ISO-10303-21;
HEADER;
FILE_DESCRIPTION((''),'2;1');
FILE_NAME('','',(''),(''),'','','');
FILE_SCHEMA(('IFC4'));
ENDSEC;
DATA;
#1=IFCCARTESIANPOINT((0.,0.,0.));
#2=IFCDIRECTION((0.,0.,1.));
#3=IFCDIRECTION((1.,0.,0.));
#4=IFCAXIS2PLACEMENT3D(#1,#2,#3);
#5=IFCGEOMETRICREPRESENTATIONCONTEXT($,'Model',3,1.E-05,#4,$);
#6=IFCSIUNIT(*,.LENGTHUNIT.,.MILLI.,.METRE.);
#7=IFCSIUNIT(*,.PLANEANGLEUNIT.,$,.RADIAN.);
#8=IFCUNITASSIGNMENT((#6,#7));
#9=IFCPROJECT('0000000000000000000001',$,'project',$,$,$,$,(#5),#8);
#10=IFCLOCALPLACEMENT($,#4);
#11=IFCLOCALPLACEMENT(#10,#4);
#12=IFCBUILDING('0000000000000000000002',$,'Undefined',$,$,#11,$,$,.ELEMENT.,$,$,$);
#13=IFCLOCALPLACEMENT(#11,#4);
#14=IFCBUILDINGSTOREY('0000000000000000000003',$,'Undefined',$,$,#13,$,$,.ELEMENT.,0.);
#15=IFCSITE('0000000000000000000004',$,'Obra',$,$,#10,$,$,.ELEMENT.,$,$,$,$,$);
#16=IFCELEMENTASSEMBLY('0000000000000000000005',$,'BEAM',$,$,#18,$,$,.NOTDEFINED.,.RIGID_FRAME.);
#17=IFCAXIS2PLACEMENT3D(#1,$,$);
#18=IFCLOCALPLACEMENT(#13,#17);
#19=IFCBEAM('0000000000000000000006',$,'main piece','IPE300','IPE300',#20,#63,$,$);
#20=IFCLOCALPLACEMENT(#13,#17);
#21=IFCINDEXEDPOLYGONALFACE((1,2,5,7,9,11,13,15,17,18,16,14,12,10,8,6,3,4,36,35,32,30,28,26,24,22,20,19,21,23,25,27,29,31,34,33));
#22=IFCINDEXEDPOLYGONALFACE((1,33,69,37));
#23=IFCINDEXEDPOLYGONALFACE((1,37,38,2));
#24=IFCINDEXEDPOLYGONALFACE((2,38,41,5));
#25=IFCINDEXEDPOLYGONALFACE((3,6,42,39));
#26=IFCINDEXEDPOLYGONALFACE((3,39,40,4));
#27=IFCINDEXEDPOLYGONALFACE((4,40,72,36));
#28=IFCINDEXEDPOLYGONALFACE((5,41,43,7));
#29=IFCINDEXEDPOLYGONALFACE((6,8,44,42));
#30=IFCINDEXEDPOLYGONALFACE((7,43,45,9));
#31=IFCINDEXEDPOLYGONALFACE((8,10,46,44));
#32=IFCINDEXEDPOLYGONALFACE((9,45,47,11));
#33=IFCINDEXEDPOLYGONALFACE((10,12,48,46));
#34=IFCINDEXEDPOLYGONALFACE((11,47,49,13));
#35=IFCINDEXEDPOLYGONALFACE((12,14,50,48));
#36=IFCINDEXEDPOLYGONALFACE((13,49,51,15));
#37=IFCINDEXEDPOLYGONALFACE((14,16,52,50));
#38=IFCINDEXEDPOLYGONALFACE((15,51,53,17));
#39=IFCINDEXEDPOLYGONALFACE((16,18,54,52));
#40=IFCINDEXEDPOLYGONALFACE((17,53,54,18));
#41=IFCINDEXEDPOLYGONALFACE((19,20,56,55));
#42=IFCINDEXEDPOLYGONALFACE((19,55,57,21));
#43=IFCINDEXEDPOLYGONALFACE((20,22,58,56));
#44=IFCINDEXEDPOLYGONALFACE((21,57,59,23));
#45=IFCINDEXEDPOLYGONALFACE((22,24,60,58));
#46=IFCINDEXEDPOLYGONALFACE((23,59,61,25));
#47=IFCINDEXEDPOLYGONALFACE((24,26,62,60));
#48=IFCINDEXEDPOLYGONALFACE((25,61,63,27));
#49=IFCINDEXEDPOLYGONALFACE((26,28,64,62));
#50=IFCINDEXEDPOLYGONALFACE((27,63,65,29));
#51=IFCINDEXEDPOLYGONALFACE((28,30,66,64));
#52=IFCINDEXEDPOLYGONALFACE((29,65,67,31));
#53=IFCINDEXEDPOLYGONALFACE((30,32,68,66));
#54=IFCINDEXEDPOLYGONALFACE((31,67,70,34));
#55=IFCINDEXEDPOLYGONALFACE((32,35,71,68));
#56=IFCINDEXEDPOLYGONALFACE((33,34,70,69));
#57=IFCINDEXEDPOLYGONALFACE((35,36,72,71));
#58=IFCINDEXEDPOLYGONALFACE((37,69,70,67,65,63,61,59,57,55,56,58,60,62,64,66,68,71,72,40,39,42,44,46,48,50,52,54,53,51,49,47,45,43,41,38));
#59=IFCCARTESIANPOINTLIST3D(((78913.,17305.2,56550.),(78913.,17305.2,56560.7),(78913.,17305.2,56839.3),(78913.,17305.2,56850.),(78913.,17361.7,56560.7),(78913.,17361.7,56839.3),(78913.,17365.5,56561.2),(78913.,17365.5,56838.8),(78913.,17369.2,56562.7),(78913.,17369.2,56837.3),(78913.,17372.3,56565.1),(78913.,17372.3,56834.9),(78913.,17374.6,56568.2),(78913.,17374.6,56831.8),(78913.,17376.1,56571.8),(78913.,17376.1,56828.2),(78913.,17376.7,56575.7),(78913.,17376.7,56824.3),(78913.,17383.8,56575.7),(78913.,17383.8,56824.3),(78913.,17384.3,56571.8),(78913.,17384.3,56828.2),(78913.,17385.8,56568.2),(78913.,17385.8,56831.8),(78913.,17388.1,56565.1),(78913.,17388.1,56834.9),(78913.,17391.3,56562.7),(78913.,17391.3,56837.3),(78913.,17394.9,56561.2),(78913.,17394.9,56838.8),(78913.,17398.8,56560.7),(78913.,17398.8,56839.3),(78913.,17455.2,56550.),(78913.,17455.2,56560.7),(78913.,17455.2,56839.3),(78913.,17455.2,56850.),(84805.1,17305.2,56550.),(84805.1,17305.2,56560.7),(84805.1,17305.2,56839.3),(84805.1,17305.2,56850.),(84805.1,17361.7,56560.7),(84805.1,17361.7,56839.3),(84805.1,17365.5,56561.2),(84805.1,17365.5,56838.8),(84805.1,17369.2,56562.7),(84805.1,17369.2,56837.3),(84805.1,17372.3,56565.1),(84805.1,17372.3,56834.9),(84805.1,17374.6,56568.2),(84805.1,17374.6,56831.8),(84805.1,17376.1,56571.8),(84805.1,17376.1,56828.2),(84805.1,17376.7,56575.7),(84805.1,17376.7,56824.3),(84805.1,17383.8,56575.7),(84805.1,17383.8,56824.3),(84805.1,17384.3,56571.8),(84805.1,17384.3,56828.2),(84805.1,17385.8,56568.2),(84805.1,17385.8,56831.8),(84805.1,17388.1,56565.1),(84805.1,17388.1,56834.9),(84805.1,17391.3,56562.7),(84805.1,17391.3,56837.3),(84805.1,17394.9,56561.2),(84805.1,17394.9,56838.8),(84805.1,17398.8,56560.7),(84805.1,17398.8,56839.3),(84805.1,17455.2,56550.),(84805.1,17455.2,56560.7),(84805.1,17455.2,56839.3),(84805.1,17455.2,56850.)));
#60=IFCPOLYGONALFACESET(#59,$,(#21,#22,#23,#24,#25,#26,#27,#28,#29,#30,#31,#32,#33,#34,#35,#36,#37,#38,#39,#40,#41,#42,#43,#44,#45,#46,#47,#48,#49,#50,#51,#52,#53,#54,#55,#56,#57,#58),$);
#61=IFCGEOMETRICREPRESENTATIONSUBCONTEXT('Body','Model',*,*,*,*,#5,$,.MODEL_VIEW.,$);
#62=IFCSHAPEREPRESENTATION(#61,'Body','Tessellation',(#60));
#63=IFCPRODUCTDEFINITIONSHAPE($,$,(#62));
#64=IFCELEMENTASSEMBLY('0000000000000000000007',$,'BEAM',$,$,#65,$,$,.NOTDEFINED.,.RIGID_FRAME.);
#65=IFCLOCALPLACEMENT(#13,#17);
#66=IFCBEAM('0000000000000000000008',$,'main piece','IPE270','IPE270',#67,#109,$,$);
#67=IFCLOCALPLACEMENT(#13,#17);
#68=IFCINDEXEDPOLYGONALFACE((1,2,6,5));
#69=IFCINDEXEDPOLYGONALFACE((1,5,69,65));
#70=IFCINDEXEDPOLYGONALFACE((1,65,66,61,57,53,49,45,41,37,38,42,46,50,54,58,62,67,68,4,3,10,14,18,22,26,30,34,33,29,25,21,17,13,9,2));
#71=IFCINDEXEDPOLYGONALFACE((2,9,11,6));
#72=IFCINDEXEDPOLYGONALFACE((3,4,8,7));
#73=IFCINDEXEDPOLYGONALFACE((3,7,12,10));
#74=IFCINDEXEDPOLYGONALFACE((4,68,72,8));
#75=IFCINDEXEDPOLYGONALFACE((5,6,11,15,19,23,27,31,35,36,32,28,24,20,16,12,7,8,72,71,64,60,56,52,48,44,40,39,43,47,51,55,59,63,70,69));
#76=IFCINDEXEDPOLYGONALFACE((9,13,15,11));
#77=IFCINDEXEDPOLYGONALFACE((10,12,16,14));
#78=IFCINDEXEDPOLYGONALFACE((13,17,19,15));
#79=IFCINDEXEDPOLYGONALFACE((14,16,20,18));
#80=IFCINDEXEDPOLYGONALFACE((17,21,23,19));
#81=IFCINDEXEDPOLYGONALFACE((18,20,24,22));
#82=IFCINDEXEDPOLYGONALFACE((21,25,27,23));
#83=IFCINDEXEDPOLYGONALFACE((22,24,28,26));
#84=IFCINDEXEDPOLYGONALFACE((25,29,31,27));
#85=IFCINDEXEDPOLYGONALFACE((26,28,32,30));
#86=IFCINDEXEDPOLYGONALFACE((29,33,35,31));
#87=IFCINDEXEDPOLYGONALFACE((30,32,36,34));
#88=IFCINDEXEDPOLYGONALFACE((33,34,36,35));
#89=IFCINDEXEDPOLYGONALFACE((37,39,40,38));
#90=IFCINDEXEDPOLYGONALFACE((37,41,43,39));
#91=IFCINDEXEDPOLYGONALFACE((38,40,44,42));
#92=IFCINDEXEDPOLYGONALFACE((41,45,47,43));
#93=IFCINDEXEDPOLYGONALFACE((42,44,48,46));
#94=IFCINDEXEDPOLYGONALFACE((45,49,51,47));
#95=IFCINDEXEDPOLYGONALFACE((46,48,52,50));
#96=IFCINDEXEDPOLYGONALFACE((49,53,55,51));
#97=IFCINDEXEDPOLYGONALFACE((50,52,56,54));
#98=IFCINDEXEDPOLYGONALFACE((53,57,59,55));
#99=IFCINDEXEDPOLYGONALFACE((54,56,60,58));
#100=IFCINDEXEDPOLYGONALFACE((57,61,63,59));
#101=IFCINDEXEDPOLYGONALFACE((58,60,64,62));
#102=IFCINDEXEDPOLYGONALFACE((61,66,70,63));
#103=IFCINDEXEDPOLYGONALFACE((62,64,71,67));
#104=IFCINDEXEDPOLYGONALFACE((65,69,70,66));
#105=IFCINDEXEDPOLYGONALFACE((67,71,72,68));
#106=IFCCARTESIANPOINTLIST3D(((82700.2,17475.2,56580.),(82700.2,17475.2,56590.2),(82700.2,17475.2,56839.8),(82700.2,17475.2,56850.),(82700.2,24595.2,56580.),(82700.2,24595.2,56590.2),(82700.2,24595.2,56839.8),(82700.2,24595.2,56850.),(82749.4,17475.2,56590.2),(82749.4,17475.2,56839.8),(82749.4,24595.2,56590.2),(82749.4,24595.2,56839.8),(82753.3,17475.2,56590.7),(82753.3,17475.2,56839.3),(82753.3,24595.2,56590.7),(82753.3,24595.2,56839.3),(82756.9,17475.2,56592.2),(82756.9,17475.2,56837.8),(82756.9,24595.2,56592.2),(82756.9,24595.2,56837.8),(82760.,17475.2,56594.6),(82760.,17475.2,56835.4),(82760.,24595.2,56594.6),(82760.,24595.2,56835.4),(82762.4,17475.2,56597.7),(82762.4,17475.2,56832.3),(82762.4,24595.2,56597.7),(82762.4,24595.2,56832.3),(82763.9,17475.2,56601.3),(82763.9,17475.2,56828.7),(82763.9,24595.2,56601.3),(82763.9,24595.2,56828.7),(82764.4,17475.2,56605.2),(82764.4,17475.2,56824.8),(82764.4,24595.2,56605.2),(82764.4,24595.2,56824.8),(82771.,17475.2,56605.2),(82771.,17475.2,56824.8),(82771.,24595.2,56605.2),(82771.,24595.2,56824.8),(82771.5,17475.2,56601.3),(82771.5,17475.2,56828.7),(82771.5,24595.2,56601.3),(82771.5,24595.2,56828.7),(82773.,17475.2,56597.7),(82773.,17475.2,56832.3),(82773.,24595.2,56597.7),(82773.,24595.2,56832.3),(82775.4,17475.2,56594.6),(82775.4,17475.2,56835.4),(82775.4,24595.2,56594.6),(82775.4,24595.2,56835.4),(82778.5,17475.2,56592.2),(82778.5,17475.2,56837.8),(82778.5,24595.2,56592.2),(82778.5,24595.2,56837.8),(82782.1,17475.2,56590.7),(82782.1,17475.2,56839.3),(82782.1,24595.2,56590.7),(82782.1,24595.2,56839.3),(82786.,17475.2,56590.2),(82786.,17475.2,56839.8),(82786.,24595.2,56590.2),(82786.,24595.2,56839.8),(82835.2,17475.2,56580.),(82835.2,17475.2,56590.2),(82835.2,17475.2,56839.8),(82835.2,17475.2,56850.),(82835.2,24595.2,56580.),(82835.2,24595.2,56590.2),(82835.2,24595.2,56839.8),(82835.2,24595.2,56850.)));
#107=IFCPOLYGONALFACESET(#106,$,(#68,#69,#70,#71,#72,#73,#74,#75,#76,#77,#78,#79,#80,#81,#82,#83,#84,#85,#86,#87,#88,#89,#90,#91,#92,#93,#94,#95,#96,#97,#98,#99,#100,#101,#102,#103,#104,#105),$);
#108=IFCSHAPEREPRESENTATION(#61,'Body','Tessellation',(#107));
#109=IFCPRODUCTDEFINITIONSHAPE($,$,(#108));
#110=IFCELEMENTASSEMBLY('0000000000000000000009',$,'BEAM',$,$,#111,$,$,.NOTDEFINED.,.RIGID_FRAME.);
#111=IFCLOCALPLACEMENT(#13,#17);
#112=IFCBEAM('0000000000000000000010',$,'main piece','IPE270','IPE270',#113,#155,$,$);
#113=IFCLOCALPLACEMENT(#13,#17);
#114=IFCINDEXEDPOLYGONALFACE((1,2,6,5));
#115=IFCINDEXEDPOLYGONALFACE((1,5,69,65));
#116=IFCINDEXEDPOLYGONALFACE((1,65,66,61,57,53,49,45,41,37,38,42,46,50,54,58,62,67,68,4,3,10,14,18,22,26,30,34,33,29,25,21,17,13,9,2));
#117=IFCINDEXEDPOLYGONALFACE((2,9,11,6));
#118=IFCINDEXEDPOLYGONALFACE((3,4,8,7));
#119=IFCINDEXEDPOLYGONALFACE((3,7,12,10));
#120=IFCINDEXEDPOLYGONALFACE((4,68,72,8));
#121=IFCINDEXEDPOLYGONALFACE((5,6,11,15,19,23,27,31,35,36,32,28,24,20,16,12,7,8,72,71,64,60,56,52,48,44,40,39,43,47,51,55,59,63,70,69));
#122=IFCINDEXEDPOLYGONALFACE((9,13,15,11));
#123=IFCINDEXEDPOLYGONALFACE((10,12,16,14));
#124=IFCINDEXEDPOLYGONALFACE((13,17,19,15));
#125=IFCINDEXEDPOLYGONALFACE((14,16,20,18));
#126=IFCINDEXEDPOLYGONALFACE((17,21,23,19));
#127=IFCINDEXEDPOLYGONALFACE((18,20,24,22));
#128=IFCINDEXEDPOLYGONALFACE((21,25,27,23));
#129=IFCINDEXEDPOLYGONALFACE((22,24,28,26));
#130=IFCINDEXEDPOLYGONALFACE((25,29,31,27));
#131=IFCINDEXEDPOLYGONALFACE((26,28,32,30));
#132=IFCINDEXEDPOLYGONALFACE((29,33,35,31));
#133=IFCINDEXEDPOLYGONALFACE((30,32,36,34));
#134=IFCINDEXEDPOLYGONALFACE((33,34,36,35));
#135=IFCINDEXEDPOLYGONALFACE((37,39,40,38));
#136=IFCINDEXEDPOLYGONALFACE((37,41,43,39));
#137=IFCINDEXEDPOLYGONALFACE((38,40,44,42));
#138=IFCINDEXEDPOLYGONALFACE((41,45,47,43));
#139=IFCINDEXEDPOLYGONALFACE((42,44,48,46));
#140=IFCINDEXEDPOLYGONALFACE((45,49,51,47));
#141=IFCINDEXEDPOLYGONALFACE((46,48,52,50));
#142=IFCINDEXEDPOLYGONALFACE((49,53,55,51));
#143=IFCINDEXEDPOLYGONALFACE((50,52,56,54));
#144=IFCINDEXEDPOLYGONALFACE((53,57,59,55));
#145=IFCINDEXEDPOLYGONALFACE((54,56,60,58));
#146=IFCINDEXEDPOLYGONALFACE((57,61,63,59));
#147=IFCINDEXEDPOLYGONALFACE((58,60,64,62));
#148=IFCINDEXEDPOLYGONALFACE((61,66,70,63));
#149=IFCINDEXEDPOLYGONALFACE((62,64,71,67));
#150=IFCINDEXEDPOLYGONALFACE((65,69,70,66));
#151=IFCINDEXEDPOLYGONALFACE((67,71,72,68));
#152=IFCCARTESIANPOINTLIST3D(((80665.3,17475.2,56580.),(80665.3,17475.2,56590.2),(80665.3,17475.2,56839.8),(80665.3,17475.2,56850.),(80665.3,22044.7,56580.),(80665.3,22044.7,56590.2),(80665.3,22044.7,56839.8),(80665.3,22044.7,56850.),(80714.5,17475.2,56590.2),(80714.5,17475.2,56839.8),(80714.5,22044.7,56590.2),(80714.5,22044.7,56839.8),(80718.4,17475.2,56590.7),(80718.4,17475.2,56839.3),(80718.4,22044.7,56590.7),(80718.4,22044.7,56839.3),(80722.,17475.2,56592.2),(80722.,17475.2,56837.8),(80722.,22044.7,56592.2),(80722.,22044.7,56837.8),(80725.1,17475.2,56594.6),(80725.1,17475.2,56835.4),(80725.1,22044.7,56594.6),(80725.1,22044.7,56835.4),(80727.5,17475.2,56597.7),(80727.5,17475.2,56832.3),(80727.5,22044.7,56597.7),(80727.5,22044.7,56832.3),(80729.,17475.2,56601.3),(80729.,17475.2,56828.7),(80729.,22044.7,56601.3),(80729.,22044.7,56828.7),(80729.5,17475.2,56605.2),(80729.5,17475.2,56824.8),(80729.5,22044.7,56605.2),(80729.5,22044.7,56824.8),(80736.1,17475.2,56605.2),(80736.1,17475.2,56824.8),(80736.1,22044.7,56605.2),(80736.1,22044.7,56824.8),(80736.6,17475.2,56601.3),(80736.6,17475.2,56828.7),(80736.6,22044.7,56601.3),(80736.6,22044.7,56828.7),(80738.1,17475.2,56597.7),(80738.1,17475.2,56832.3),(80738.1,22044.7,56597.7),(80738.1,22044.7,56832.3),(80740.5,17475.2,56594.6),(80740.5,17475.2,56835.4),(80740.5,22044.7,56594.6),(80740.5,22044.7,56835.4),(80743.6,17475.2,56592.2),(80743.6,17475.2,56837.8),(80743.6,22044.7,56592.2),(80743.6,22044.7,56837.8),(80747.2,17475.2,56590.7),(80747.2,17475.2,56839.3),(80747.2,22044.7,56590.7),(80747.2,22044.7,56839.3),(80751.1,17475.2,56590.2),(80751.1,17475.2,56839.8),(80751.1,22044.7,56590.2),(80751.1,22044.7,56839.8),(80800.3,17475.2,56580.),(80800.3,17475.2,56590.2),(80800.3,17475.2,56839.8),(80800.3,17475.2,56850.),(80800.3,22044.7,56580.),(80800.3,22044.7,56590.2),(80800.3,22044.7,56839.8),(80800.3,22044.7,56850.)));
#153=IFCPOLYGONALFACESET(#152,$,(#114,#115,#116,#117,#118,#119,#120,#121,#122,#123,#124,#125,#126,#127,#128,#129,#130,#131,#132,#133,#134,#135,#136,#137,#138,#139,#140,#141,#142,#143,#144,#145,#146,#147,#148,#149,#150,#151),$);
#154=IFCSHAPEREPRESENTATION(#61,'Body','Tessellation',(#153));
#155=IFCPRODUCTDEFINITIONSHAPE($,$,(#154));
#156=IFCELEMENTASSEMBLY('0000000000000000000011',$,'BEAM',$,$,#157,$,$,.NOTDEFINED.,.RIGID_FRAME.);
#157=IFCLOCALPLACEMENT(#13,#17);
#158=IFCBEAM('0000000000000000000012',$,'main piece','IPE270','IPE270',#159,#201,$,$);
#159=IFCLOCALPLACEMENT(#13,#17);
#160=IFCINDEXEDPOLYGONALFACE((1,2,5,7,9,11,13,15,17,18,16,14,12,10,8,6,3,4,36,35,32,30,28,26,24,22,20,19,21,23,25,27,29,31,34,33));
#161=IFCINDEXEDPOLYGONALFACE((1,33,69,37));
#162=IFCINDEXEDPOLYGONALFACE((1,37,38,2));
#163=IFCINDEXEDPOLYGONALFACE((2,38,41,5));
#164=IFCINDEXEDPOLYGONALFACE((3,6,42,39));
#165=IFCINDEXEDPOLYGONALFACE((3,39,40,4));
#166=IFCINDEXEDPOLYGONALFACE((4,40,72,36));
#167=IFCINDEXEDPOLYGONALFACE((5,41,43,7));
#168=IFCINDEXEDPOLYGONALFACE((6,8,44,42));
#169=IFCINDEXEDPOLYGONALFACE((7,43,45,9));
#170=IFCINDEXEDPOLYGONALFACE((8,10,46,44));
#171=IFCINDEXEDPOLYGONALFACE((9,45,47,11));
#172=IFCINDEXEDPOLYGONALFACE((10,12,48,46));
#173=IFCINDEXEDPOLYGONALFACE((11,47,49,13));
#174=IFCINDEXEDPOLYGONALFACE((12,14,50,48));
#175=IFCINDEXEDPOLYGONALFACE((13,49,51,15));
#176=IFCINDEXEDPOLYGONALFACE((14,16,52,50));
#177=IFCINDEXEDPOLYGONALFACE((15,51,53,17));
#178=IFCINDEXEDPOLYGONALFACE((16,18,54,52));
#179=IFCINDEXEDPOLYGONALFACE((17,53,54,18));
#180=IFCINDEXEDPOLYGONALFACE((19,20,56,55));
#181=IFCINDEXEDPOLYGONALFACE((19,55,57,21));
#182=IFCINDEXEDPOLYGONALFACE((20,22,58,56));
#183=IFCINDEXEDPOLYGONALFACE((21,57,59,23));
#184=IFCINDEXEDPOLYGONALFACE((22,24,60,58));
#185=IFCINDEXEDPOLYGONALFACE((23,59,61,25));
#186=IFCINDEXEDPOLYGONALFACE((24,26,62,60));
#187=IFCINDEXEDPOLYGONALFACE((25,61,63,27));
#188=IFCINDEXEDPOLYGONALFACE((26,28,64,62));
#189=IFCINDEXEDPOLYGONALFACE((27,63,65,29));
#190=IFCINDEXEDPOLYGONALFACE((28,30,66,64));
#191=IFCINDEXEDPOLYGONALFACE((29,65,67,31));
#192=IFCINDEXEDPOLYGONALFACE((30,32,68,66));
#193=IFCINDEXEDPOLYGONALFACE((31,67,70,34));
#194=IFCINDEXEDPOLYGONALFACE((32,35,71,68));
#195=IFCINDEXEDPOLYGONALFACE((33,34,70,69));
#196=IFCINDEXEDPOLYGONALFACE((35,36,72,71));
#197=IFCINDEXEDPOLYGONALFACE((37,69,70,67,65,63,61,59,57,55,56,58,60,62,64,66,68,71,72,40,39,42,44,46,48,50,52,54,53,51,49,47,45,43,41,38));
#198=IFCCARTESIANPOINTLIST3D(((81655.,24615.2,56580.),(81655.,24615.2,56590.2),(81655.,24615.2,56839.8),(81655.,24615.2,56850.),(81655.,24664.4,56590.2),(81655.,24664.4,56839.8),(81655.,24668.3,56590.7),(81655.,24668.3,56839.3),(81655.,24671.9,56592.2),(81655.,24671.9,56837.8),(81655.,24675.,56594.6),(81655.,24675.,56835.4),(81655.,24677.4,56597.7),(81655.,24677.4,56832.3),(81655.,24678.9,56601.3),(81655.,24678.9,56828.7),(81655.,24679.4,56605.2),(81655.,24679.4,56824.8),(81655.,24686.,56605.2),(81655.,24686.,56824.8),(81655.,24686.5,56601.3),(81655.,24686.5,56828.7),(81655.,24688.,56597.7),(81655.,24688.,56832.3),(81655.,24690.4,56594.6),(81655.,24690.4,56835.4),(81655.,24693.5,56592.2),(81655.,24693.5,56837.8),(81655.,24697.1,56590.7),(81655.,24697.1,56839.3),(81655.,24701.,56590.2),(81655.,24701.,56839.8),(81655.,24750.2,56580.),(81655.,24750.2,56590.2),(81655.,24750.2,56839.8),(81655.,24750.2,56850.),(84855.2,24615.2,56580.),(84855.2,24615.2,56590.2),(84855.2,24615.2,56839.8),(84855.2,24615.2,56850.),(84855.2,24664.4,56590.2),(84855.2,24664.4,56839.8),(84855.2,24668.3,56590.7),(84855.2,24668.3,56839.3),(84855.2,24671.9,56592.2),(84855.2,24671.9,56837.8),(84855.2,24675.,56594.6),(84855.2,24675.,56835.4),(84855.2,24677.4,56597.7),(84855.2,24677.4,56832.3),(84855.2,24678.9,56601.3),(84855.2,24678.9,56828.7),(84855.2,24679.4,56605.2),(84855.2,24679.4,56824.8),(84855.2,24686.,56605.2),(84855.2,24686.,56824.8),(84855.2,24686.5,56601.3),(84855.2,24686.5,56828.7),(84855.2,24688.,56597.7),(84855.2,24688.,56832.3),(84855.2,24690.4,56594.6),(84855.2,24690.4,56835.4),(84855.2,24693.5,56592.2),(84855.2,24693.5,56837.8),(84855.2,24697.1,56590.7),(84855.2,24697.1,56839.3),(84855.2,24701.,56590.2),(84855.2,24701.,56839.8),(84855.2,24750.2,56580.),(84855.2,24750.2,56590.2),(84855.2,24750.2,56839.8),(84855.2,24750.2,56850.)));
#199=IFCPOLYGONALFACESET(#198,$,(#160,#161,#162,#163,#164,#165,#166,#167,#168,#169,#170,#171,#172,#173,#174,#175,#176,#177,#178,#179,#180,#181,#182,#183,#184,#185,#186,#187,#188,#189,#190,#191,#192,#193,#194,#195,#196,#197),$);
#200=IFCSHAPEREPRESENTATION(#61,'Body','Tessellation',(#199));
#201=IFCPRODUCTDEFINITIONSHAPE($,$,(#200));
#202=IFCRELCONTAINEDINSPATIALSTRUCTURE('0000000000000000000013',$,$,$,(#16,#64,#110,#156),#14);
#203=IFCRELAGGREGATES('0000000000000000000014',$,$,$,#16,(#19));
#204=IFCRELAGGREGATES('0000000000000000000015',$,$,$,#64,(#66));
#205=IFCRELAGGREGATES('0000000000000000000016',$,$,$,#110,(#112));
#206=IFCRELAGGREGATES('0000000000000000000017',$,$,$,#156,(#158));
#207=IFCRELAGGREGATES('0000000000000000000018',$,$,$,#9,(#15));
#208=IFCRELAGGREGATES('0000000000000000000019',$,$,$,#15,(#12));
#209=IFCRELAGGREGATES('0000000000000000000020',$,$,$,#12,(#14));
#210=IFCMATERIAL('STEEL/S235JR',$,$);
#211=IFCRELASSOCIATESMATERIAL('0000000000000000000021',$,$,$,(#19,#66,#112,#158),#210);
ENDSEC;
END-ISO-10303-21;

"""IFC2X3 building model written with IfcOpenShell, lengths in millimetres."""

from ifc_helpers import new_model, si_unit, frame, origin_with_axes, origin_2d_with_axis, place, context, subcontext, project, spatial, i_section, extrude, material, element, aggregate, save


model = new_model("IFC2X3")

# Units and contexts
model_context = context("Model", 3, precision=1e-05, world=origin_with_axes())
body_context = subcontext(model_context, "Body", "Model", "MODEL_VIEW")
ifc_project = project(units=[si_unit("LENGTHUNIT", "METRE", prefix="MILLI"), si_unit("PLANEANGLEUNIT", "RADIAN")], contexts=[model_context])

# Site, building, storey
site_placement = place(None, origin_with_axes())
site = spatial("IfcSite", under=ifc_project, at=site_placement, Name="Obra", CompositionType="ELEMENT")
building_placement = place(site_placement, origin_with_axes())
building = spatial("IfcBuilding", under=site, at=building_placement, Name="Undefined", CompositionType="ELEMENT")
storey_placement = place(building_placement, origin_with_axes())
storey = spatial("IfcBuildingStorey", under=building, at=storey_placement, Name="Undefined", CompositionType="ELEMENT", Elevation=0.0)

# Element assemblies, beams
assembly_1_placement = place(storey_placement, origin_with_axes())
assembly_1 = element("IfcElementAssembly", 1, at=assembly_1_placement, inside=storey, Name="BEAM", AssemblyPlace="NOTDEFINED", PredefinedType="RIGID_FRAME")
ifc_material = material(Name="STEEL/S235JR")
beam_1_placement = place(assembly_1_placement, frame((78913.0, 17380.2, 56700.0), z_axis=(0.0, 0.0, 1.0), x_axis=(1.0, 0.0, 0.0)))
beam_1 = element("IfcBeam", 2, at=beam_1_placement, material=ifc_material, Name="main piece", Description="IPE300", ObjectType="IPE300", context=body_context, shape_type="SweptSolid", body=[
    extrude(i_section(OverallWidth=150.0, OverallDepth=300.0, WebThickness=7.1, FlangeThickness=10.7, FilletRadius=15.0, at=origin_2d_with_axis()), frame((5892.1, 0.0, 0.0), z_axis=(-1.0, 0.0, 0.0), x_axis=(0.0, -1.0, 0.0)), (0.0, 0.0, 1.0), 5892.1),
])
aggregate(assembly_1, [beam_1])
assembly_2_placement = place(storey_placement, origin_with_axes())
assembly_2 = element("IfcElementAssembly", 3, at=assembly_2_placement, inside=storey, Name="BEAM", AssemblyPlace="NOTDEFINED", PredefinedType="RIGID_FRAME")
beam_2_placement = place(assembly_2_placement, frame((82767.7, 17475.2, 56715.0), z_axis=(0.0, 0.0, 1.0), x_axis=(0.0, 1.0, 0.0)))
beam_2 = element("IfcBeam", 4, at=beam_2_placement, material=ifc_material, Name="main piece", Description="IPE270", ObjectType="IPE270", context=body_context, shape_type="SweptSolid", body=[
    extrude(i_section(OverallWidth=135.0, OverallDepth=270.0, WebThickness=6.6, FlangeThickness=10.2, FilletRadius=15.0, at=origin_2d_with_axis()), frame((7120.0, 0.0, 0.0), z_axis=(-1.0, 0.0, 0.0), x_axis=(0.0, -1.0, 0.0)), (0.0, 0.0, 1.0), 7120.0),
])
aggregate(assembly_2, [beam_2])
assembly_3_placement = place(storey_placement, origin_with_axes())
assembly_3 = element("IfcElementAssembly", 5, at=assembly_3_placement, inside=storey, Name="BEAM", AssemblyPlace="NOTDEFINED", PredefinedType="RIGID_FRAME")
beam_3_placement = place(assembly_3_placement, frame((80732.8, 17475.2, 56715.0), z_axis=(0.0, 0.0, 1.0), x_axis=(0.0, 1.0, 0.0)))
beam_3 = element("IfcBeam", 6, at=beam_3_placement, material=ifc_material, Name="main piece", Description="IPE270", ObjectType="IPE270", context=body_context, shape_type="SweptSolid", body=[
    extrude(i_section(OverallWidth=135.0, OverallDepth=270.0, WebThickness=6.6, FlangeThickness=10.2, FilletRadius=15.0, at=origin_2d_with_axis()), frame((4569.5, 0.0, 0.0), z_axis=(-1.0, 0.0, 0.0), x_axis=(0.0, -1.0, 0.0)), (0.0, 0.0, 1.0), 4569.5),
])
aggregate(assembly_3, [beam_3])
assembly_4_placement = place(storey_placement, origin_with_axes())
assembly_4 = element("IfcElementAssembly", 7, at=assembly_4_placement, inside=storey, Name="BEAM", AssemblyPlace="NOTDEFINED", PredefinedType="RIGID_FRAME")
beam_4_placement = place(assembly_4_placement, frame((81655.0, 24682.7, 56715.0), z_axis=(0.0, 0.0, 1.0), x_axis=(1.0, 0.000002, 0.0)))
beam_4 = element("IfcBeam", 8, at=beam_4_placement, material=ifc_material, Name="main piece", Description="IPE270", ObjectType="IPE270", context=body_context, shape_type="SweptSolid", body=[
    extrude(i_section(OverallWidth=135.0, OverallDepth=270.0, WebThickness=6.6, FlangeThickness=10.2, FilletRadius=15.0, at=origin_2d_with_axis()), frame((3200.1, 0.0, 0.0), z_axis=(-1.0, 0.0, 0.0), x_axis=(0.0, -1.0, 0.0)), (0.0, 0.0, 1.0), 3200.1),
])
aggregate(assembly_4, [beam_4])

save(model, "model.ifc")
